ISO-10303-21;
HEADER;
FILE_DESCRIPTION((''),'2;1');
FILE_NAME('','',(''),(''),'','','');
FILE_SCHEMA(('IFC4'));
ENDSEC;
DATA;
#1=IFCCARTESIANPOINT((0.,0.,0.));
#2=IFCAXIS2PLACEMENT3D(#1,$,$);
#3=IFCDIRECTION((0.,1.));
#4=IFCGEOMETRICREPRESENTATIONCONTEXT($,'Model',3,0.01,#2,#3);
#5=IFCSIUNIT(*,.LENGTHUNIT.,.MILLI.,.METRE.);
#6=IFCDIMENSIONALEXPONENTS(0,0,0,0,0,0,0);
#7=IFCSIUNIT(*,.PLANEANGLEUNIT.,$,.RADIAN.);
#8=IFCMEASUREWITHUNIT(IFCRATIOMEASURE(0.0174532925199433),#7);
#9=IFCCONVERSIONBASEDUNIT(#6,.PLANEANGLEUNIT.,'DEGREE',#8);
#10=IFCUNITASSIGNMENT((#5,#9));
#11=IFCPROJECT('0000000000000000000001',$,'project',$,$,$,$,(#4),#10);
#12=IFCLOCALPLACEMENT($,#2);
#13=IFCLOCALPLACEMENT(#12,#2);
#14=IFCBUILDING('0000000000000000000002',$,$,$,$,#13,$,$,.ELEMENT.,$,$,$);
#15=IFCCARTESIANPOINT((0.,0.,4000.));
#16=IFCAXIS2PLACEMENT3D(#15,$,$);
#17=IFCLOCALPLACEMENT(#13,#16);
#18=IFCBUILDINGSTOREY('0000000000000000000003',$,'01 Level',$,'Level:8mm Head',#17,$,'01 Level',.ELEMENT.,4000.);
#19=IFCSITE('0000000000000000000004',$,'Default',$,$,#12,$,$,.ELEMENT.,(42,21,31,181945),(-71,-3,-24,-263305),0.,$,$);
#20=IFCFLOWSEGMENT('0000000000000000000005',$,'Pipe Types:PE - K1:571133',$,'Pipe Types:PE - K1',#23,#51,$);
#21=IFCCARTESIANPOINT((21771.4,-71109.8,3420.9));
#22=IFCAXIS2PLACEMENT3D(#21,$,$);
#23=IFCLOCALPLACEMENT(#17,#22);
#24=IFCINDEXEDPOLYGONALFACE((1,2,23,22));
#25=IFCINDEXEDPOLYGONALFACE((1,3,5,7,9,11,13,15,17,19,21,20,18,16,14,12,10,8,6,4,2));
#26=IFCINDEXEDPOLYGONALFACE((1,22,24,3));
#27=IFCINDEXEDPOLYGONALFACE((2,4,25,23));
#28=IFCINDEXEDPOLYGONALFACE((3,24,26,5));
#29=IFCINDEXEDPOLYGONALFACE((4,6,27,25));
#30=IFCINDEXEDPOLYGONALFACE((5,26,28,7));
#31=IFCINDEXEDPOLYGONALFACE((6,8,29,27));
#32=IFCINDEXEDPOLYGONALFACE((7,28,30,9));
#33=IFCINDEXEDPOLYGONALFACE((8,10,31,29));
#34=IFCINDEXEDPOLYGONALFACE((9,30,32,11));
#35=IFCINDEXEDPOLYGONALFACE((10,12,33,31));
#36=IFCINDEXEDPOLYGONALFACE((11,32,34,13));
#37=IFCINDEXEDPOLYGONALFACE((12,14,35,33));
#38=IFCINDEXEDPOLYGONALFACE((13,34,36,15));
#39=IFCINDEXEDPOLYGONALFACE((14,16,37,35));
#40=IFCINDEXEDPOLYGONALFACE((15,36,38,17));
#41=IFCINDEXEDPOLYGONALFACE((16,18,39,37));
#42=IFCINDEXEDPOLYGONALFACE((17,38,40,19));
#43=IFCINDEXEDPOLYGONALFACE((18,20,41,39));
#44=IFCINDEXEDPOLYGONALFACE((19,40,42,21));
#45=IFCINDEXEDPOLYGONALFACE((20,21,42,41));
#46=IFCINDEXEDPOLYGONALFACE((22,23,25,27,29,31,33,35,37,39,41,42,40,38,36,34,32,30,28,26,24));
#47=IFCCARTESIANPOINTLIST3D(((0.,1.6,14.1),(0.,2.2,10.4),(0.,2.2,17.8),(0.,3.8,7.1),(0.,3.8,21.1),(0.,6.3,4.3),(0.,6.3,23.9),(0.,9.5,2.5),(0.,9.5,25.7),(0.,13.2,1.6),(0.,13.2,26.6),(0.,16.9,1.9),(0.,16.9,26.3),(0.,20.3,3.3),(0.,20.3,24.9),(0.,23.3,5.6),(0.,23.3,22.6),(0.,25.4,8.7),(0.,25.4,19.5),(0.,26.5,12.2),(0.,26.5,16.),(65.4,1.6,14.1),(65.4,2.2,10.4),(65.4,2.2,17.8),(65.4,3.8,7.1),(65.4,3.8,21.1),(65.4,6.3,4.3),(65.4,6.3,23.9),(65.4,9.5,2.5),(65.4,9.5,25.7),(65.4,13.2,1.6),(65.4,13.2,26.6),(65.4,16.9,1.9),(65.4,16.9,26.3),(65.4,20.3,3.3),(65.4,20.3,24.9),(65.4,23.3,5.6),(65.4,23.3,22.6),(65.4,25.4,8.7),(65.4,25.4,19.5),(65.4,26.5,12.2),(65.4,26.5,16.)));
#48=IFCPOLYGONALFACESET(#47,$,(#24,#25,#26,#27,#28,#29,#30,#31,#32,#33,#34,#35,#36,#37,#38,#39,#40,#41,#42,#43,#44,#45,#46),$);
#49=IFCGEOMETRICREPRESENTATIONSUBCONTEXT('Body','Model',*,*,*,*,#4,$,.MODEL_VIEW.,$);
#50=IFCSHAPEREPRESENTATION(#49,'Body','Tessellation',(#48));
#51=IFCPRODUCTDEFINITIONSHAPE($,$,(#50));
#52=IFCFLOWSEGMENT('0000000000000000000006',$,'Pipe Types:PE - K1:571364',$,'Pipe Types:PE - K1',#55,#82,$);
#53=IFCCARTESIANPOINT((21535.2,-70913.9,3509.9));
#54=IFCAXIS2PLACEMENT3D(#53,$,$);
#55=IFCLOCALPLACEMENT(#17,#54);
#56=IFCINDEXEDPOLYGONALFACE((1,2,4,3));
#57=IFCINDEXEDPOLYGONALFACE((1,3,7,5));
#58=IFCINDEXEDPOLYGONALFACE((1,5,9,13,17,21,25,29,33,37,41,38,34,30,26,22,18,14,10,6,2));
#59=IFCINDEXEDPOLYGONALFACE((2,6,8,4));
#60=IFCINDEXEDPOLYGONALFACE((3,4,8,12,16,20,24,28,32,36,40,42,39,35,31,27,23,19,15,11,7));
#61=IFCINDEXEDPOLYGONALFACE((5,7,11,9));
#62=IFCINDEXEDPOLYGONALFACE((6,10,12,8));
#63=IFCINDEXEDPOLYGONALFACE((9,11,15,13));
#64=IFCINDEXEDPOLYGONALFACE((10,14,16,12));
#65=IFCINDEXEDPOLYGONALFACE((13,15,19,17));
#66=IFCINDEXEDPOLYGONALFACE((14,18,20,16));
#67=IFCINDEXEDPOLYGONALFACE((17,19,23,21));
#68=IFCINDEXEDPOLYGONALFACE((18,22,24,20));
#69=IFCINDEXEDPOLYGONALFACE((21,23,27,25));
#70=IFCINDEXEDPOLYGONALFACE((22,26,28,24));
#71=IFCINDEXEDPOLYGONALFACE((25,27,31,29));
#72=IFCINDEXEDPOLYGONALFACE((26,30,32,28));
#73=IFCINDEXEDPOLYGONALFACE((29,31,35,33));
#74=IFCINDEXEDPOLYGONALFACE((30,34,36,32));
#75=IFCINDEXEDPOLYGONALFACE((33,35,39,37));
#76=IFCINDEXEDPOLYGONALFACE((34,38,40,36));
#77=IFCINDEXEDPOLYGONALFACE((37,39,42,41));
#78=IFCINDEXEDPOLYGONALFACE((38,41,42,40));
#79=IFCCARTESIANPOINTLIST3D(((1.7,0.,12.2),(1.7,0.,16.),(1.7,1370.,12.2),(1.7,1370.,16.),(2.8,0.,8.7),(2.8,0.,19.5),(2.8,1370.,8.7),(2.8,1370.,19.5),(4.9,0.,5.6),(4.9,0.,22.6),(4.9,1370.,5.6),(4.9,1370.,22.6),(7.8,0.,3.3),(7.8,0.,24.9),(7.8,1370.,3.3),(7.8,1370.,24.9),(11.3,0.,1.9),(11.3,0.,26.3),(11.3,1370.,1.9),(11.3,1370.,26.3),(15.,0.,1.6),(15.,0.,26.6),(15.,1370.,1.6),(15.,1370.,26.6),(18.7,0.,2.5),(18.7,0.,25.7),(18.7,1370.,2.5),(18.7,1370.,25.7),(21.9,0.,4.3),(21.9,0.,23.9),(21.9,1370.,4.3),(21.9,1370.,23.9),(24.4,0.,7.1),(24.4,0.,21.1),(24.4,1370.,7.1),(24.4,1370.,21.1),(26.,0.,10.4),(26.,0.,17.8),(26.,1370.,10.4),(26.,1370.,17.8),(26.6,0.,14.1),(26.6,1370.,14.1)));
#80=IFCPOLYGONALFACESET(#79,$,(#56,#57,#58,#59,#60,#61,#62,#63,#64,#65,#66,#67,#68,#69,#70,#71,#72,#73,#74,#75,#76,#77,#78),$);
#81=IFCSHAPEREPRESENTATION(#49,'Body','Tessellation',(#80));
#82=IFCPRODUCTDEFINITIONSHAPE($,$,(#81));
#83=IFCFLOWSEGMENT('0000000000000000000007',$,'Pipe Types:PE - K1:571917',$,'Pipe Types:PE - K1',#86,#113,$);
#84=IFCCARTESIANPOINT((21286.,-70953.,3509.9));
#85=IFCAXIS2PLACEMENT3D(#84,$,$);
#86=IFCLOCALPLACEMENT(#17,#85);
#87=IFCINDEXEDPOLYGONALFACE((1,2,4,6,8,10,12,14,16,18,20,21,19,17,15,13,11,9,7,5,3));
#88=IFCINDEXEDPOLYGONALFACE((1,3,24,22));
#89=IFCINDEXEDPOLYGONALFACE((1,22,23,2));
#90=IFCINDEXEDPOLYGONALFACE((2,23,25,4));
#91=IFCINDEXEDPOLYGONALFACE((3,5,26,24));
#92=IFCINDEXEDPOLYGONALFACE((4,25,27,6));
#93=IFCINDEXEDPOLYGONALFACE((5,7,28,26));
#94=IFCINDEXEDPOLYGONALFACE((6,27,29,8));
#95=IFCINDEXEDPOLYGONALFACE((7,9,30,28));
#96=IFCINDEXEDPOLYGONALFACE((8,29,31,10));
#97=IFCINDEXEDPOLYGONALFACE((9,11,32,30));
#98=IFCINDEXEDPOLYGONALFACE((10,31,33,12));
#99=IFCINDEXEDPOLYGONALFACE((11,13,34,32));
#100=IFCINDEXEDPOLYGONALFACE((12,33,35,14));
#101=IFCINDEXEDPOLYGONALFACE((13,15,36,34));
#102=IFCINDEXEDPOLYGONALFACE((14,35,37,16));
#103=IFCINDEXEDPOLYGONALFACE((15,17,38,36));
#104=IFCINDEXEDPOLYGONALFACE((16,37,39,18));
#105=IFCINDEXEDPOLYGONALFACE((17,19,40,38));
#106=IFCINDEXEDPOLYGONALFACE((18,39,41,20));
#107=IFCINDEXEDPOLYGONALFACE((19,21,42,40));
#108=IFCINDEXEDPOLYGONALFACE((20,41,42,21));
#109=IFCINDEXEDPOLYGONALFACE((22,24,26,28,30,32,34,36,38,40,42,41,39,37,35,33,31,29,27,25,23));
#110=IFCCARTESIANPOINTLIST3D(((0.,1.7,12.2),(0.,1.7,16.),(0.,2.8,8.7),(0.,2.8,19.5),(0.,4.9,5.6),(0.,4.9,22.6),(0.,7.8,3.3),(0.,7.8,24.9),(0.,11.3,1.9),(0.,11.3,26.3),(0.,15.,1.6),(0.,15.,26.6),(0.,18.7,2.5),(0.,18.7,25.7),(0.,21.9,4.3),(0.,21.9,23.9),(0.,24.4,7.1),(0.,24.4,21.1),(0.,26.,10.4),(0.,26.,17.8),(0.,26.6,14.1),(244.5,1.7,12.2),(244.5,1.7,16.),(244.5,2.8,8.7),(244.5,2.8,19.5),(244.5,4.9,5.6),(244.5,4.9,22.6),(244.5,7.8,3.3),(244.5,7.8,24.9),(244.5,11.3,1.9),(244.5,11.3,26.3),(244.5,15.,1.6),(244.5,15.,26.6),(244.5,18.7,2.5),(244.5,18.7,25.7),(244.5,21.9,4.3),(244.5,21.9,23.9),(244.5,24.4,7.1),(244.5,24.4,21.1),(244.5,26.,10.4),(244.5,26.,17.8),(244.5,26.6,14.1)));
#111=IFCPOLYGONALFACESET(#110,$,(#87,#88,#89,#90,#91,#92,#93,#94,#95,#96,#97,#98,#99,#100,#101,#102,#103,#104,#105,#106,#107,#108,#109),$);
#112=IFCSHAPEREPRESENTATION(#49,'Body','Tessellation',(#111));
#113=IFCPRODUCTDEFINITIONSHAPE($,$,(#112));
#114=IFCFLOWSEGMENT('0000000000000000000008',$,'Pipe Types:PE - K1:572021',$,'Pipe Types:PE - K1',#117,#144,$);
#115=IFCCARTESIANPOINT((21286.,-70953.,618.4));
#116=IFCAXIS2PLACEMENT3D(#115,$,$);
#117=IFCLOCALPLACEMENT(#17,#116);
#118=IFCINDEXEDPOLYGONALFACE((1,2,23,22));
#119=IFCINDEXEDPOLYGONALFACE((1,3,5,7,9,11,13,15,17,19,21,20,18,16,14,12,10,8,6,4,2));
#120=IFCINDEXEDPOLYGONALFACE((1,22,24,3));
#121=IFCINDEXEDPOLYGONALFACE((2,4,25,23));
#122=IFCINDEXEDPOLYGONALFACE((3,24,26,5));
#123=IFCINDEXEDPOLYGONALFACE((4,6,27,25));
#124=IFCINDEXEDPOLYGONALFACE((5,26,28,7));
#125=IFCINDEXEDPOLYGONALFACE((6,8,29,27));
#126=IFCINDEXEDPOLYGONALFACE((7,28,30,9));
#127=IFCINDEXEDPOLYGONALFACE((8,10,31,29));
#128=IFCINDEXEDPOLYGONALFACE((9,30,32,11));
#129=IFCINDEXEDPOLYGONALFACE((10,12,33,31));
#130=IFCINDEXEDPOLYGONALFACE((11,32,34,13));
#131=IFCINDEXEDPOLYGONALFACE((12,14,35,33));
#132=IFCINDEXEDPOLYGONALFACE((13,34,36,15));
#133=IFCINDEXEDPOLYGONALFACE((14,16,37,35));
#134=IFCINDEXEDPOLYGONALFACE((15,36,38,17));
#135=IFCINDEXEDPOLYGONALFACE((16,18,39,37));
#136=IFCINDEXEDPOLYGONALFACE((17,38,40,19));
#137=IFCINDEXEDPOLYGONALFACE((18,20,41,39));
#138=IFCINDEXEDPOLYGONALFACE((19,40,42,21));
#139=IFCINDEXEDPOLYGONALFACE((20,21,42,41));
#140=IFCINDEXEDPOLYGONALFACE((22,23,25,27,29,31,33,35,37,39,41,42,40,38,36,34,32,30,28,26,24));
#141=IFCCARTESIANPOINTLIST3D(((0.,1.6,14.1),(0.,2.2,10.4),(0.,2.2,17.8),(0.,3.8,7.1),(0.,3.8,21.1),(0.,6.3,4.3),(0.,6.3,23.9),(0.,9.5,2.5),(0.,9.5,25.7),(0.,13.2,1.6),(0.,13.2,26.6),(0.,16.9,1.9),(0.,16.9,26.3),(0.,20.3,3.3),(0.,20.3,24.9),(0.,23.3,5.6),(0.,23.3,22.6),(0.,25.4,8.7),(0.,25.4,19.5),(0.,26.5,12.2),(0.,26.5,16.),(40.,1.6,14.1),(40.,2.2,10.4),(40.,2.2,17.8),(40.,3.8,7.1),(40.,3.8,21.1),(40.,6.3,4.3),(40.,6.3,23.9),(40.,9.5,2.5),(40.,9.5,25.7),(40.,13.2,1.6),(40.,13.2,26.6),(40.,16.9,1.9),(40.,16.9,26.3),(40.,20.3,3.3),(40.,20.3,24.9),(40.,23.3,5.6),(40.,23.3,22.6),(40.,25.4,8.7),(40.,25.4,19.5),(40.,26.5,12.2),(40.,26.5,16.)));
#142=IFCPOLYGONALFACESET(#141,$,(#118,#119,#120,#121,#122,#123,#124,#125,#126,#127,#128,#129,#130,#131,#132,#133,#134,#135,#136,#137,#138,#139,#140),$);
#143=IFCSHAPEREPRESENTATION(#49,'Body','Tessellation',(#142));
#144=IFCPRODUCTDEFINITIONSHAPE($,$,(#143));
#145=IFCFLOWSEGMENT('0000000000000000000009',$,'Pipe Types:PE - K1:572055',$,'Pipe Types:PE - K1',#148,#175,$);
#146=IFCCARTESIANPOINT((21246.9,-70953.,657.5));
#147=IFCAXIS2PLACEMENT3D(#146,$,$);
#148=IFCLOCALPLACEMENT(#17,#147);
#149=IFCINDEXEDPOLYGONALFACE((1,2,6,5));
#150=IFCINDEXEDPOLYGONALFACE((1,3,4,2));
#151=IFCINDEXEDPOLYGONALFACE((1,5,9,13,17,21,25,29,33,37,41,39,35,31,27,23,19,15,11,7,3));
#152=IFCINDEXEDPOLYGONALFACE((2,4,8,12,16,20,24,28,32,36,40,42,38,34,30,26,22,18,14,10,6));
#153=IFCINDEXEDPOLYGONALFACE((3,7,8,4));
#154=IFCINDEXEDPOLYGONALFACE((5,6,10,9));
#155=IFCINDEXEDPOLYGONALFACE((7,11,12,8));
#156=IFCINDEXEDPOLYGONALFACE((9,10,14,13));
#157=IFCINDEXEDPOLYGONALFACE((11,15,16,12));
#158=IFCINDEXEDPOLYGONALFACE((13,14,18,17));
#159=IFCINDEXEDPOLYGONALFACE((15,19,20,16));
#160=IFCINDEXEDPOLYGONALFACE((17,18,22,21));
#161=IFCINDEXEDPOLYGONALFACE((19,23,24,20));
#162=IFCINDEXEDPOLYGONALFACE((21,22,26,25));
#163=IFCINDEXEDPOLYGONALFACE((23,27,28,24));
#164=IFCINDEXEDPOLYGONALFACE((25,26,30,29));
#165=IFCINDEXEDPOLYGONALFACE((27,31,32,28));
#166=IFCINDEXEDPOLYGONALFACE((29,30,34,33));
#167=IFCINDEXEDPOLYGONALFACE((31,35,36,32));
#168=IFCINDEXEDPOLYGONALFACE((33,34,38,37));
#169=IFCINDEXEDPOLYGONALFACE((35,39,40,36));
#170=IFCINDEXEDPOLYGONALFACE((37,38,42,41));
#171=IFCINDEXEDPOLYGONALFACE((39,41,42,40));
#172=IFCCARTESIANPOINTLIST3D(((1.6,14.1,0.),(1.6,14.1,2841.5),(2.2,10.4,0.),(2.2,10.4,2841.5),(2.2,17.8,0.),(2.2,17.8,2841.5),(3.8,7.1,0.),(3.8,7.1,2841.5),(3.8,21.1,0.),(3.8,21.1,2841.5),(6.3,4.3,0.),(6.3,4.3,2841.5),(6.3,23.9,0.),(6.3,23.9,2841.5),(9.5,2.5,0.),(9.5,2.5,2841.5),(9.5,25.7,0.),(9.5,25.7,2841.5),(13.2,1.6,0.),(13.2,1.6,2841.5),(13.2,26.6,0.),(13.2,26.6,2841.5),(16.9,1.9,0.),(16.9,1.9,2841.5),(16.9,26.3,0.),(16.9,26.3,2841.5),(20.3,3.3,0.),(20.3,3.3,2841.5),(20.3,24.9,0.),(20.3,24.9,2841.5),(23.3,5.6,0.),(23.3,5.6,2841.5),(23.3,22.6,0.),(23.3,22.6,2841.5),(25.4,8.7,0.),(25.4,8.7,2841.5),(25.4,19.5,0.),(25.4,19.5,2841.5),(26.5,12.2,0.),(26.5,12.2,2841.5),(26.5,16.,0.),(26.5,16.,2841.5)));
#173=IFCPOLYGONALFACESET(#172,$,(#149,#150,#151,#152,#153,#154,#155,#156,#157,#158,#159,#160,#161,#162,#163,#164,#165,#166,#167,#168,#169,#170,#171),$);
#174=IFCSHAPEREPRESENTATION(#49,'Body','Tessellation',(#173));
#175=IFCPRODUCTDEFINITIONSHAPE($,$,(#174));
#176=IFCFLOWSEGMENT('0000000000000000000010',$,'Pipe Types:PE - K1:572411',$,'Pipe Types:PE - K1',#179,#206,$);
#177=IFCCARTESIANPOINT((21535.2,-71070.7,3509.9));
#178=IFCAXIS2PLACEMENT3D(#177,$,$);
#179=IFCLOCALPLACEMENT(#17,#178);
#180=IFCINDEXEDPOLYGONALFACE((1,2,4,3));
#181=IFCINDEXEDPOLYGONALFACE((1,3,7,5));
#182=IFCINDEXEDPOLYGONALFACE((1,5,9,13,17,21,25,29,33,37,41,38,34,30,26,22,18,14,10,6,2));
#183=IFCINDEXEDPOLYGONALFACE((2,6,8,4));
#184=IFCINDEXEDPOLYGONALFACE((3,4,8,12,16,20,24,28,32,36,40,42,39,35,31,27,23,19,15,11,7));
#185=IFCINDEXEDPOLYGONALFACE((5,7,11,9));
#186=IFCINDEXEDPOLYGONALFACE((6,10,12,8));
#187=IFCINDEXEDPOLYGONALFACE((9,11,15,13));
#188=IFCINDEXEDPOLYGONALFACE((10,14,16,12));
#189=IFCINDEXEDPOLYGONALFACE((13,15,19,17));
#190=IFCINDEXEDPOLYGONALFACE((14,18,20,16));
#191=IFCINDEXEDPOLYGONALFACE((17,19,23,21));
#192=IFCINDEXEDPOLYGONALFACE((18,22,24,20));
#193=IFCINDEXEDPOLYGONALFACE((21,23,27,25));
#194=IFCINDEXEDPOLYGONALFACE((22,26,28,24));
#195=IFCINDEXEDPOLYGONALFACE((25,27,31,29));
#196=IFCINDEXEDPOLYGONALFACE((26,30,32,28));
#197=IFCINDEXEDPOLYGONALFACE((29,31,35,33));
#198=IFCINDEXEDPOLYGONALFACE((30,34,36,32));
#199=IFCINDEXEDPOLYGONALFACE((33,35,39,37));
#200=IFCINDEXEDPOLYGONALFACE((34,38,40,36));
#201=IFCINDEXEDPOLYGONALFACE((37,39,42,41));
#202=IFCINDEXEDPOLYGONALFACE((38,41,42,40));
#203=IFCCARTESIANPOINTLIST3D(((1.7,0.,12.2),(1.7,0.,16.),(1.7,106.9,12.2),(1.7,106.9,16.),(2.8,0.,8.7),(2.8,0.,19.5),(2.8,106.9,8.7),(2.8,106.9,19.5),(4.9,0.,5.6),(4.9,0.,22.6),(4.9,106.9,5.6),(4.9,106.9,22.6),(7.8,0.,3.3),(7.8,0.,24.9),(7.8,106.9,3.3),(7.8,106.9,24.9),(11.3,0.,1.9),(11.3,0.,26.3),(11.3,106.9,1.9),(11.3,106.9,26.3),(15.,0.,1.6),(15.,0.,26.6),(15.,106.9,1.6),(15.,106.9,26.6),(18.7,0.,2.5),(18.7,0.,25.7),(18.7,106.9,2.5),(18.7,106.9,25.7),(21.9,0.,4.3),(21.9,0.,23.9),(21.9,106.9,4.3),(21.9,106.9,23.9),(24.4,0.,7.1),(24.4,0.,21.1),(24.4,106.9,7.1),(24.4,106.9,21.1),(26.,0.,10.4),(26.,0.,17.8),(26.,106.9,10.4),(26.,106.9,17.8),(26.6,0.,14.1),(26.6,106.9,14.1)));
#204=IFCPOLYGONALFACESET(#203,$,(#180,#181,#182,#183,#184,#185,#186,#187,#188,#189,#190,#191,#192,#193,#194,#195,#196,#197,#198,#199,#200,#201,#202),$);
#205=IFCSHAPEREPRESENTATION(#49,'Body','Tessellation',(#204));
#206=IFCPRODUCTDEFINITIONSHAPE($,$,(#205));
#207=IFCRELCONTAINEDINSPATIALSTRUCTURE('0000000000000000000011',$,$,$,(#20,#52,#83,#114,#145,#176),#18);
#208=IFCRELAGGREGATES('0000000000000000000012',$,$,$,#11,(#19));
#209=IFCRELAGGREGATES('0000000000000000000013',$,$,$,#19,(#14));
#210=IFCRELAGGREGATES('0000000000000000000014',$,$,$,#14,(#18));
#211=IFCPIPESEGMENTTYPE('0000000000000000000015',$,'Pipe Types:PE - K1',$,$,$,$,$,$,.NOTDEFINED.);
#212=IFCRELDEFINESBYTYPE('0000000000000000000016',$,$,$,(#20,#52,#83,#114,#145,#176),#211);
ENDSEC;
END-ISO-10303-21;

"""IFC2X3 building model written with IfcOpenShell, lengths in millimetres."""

from ifc_helpers import new_model, entity, si_unit, converted_unit, direction, frame, frame_2d, origin, origin_2d_with_axis, place, context, subcontext, project, spatial, circle, extrude, type_object, element, save


model = new_model("IFC2X3")

# Units and contexts
model_context = context("Model", 3, precision=0.01, world=origin(), true_north=direction((0.0, 1.0)))
body_context = subcontext(model_context, "Body", "Model", "MODEL_VIEW")
ifc_project = project(units=[si_unit("LENGTHUNIT", "METRE", prefix="MILLI"), converted_unit("PLANEANGLEUNIT", "DEGREE", entity("IfcRatioMeasure", 0.0174532925199433), si_unit("PLANEANGLEUNIT", "RADIAN"), dimensions=[0, 0, 0, 0, 0, 0, 0])], contexts=[model_context])

# Site, building, storey
site_placement = place(None, origin())
site = spatial("IfcSite", under=ifc_project, at=site_placement, Name="Default", CompositionType="ELEMENT", RefLatitude=(42, 21, 31, 181945), RefLongitude=(-71, -3, -24, -263305), RefElevation=0.0)
building_placement = place(site_placement, origin())
building = spatial("IfcBuilding", under=site, at=building_placement, CompositionType="ELEMENT")
storey_placement = place(building_placement, frame((0.0, 0.0, 4000.0)))
storey = spatial("IfcBuildingStorey", under=building, at=storey_placement, Name="01 Level", ObjectType="Level:8mm Head", LongName="01 Level", CompositionType="ELEMENT", Elevation=4000.0)

# Flow segments
pipe_segment_type = type_object("IfcPipeSegmentType", Name="Pipe Types:PE - K1", PredefinedType="NOTDEFINED")
flow_segment_1_placement = place(storey_placement, frame((21771.4, -71109.8, 3420.9)))
element("IfcFlowSegment", 1, at=flow_segment_1_placement, inside=storey, type_object=pipe_segment_type, Name="Pipe Types:PE - K1:571133", ObjectType="Pipe Types:PE - K1", context=body_context, shape_type="SweptSolid", body=[
    extrude(circle(Radius=12.5, at=origin_2d_with_axis()), frame((0.0, 14.1, 14.1), z_axis=(1.0, 0.0, 0.0), x_axis=(0.0, -1.0, 0.0)), (0.0, 0.0, 1.0), 65.4),
])
flow_segment_2_placement = place(storey_placement, frame((21535.2, -70913.9, 3509.9)))
element("IfcFlowSegment", 2, at=flow_segment_2_placement, inside=storey, type_object=pipe_segment_type, Name="Pipe Types:PE - K1:571364", ObjectType="Pipe Types:PE - K1", context=body_context, shape_type="SweptSolid", body=[
    extrude(circle(Radius=12.5, at=origin_2d_with_axis()), frame((14.1, 0.0, 14.1), z_axis=(0.0, 1.0, 0.0), x_axis=(1.0, 0.0, 0.0)), (0.0, 0.0, 1.0), 1370.0),
])
flow_segment_3_placement = place(storey_placement, frame((21286.0, -70953.0, 3509.9)))
element("IfcFlowSegment", 3, at=flow_segment_3_placement, inside=storey, type_object=pipe_segment_type, Name="Pipe Types:PE - K1:571917", ObjectType="Pipe Types:PE - K1", context=body_context, shape_type="SweptSolid", body=[
    extrude(circle(Radius=12.5, at=frame_2d((0.0, 0.0), x_axis=(1.0, 0.0))), frame((0.0, 14.1, 14.1), z_axis=(1.0, 0.0, 0.0), x_axis=(0.0, 1.0, 0.0)), (0.0, 0.0, 1.0), 244.5),
])
flow_segment_4_placement = place(storey_placement, frame((21286.0, -70953.0, 618.4)))
element("IfcFlowSegment", 4, at=flow_segment_4_placement, inside=storey, type_object=pipe_segment_type, Name="Pipe Types:PE - K1:572021", ObjectType="Pipe Types:PE - K1", context=body_context, shape_type="SweptSolid", body=[
    extrude(circle(Radius=12.5, at=origin_2d_with_axis()), frame((0.0, 14.1, 14.1), z_axis=(1.0, 0.0, 0.0), x_axis=(0.0, -1.0, 0.0)), (0.0, 0.0, 1.0), 40.0),
])
flow_segment_5_placement = place(storey_placement, frame((21246.9, -70953.0, 657.5)))
element("IfcFlowSegment", 5, at=flow_segment_5_placement, inside=storey, type_object=pipe_segment_type, Name="Pipe Types:PE - K1:572055", ObjectType="Pipe Types:PE - K1", context=body_context, shape_type="SweptSolid", body=[
    extrude(circle(Radius=12.5, at=origin_2d_with_axis()), frame((14.1, 14.1, 0.0), z_axis=(0.0, 0.0, 1.0), x_axis=(-1.0, 0.0, 0.0)), (0.0, 0.0, 1.0), 2841.5),
])
flow_segment_6_placement = place(storey_placement, frame((21535.2, -71070.7, 3509.9)))
element("IfcFlowSegment", 6, at=flow_segment_6_placement, inside=storey, type_object=pipe_segment_type, Name="Pipe Types:PE - K1:572411", ObjectType="Pipe Types:PE - K1", context=body_context, shape_type="SweptSolid", body=[
    extrude(circle(Radius=12.5, at=frame_2d((0.0, 0.0), x_axis=(1.0, 0.0))), frame((14.1, 0.0, 14.1), z_axis=(0.0, 1.0, 0.0), x_axis=(1.0, 0.0, 0.0)), (0.0, 0.0, 1.0), 106.9),
])

save(model, "model.ifc")
